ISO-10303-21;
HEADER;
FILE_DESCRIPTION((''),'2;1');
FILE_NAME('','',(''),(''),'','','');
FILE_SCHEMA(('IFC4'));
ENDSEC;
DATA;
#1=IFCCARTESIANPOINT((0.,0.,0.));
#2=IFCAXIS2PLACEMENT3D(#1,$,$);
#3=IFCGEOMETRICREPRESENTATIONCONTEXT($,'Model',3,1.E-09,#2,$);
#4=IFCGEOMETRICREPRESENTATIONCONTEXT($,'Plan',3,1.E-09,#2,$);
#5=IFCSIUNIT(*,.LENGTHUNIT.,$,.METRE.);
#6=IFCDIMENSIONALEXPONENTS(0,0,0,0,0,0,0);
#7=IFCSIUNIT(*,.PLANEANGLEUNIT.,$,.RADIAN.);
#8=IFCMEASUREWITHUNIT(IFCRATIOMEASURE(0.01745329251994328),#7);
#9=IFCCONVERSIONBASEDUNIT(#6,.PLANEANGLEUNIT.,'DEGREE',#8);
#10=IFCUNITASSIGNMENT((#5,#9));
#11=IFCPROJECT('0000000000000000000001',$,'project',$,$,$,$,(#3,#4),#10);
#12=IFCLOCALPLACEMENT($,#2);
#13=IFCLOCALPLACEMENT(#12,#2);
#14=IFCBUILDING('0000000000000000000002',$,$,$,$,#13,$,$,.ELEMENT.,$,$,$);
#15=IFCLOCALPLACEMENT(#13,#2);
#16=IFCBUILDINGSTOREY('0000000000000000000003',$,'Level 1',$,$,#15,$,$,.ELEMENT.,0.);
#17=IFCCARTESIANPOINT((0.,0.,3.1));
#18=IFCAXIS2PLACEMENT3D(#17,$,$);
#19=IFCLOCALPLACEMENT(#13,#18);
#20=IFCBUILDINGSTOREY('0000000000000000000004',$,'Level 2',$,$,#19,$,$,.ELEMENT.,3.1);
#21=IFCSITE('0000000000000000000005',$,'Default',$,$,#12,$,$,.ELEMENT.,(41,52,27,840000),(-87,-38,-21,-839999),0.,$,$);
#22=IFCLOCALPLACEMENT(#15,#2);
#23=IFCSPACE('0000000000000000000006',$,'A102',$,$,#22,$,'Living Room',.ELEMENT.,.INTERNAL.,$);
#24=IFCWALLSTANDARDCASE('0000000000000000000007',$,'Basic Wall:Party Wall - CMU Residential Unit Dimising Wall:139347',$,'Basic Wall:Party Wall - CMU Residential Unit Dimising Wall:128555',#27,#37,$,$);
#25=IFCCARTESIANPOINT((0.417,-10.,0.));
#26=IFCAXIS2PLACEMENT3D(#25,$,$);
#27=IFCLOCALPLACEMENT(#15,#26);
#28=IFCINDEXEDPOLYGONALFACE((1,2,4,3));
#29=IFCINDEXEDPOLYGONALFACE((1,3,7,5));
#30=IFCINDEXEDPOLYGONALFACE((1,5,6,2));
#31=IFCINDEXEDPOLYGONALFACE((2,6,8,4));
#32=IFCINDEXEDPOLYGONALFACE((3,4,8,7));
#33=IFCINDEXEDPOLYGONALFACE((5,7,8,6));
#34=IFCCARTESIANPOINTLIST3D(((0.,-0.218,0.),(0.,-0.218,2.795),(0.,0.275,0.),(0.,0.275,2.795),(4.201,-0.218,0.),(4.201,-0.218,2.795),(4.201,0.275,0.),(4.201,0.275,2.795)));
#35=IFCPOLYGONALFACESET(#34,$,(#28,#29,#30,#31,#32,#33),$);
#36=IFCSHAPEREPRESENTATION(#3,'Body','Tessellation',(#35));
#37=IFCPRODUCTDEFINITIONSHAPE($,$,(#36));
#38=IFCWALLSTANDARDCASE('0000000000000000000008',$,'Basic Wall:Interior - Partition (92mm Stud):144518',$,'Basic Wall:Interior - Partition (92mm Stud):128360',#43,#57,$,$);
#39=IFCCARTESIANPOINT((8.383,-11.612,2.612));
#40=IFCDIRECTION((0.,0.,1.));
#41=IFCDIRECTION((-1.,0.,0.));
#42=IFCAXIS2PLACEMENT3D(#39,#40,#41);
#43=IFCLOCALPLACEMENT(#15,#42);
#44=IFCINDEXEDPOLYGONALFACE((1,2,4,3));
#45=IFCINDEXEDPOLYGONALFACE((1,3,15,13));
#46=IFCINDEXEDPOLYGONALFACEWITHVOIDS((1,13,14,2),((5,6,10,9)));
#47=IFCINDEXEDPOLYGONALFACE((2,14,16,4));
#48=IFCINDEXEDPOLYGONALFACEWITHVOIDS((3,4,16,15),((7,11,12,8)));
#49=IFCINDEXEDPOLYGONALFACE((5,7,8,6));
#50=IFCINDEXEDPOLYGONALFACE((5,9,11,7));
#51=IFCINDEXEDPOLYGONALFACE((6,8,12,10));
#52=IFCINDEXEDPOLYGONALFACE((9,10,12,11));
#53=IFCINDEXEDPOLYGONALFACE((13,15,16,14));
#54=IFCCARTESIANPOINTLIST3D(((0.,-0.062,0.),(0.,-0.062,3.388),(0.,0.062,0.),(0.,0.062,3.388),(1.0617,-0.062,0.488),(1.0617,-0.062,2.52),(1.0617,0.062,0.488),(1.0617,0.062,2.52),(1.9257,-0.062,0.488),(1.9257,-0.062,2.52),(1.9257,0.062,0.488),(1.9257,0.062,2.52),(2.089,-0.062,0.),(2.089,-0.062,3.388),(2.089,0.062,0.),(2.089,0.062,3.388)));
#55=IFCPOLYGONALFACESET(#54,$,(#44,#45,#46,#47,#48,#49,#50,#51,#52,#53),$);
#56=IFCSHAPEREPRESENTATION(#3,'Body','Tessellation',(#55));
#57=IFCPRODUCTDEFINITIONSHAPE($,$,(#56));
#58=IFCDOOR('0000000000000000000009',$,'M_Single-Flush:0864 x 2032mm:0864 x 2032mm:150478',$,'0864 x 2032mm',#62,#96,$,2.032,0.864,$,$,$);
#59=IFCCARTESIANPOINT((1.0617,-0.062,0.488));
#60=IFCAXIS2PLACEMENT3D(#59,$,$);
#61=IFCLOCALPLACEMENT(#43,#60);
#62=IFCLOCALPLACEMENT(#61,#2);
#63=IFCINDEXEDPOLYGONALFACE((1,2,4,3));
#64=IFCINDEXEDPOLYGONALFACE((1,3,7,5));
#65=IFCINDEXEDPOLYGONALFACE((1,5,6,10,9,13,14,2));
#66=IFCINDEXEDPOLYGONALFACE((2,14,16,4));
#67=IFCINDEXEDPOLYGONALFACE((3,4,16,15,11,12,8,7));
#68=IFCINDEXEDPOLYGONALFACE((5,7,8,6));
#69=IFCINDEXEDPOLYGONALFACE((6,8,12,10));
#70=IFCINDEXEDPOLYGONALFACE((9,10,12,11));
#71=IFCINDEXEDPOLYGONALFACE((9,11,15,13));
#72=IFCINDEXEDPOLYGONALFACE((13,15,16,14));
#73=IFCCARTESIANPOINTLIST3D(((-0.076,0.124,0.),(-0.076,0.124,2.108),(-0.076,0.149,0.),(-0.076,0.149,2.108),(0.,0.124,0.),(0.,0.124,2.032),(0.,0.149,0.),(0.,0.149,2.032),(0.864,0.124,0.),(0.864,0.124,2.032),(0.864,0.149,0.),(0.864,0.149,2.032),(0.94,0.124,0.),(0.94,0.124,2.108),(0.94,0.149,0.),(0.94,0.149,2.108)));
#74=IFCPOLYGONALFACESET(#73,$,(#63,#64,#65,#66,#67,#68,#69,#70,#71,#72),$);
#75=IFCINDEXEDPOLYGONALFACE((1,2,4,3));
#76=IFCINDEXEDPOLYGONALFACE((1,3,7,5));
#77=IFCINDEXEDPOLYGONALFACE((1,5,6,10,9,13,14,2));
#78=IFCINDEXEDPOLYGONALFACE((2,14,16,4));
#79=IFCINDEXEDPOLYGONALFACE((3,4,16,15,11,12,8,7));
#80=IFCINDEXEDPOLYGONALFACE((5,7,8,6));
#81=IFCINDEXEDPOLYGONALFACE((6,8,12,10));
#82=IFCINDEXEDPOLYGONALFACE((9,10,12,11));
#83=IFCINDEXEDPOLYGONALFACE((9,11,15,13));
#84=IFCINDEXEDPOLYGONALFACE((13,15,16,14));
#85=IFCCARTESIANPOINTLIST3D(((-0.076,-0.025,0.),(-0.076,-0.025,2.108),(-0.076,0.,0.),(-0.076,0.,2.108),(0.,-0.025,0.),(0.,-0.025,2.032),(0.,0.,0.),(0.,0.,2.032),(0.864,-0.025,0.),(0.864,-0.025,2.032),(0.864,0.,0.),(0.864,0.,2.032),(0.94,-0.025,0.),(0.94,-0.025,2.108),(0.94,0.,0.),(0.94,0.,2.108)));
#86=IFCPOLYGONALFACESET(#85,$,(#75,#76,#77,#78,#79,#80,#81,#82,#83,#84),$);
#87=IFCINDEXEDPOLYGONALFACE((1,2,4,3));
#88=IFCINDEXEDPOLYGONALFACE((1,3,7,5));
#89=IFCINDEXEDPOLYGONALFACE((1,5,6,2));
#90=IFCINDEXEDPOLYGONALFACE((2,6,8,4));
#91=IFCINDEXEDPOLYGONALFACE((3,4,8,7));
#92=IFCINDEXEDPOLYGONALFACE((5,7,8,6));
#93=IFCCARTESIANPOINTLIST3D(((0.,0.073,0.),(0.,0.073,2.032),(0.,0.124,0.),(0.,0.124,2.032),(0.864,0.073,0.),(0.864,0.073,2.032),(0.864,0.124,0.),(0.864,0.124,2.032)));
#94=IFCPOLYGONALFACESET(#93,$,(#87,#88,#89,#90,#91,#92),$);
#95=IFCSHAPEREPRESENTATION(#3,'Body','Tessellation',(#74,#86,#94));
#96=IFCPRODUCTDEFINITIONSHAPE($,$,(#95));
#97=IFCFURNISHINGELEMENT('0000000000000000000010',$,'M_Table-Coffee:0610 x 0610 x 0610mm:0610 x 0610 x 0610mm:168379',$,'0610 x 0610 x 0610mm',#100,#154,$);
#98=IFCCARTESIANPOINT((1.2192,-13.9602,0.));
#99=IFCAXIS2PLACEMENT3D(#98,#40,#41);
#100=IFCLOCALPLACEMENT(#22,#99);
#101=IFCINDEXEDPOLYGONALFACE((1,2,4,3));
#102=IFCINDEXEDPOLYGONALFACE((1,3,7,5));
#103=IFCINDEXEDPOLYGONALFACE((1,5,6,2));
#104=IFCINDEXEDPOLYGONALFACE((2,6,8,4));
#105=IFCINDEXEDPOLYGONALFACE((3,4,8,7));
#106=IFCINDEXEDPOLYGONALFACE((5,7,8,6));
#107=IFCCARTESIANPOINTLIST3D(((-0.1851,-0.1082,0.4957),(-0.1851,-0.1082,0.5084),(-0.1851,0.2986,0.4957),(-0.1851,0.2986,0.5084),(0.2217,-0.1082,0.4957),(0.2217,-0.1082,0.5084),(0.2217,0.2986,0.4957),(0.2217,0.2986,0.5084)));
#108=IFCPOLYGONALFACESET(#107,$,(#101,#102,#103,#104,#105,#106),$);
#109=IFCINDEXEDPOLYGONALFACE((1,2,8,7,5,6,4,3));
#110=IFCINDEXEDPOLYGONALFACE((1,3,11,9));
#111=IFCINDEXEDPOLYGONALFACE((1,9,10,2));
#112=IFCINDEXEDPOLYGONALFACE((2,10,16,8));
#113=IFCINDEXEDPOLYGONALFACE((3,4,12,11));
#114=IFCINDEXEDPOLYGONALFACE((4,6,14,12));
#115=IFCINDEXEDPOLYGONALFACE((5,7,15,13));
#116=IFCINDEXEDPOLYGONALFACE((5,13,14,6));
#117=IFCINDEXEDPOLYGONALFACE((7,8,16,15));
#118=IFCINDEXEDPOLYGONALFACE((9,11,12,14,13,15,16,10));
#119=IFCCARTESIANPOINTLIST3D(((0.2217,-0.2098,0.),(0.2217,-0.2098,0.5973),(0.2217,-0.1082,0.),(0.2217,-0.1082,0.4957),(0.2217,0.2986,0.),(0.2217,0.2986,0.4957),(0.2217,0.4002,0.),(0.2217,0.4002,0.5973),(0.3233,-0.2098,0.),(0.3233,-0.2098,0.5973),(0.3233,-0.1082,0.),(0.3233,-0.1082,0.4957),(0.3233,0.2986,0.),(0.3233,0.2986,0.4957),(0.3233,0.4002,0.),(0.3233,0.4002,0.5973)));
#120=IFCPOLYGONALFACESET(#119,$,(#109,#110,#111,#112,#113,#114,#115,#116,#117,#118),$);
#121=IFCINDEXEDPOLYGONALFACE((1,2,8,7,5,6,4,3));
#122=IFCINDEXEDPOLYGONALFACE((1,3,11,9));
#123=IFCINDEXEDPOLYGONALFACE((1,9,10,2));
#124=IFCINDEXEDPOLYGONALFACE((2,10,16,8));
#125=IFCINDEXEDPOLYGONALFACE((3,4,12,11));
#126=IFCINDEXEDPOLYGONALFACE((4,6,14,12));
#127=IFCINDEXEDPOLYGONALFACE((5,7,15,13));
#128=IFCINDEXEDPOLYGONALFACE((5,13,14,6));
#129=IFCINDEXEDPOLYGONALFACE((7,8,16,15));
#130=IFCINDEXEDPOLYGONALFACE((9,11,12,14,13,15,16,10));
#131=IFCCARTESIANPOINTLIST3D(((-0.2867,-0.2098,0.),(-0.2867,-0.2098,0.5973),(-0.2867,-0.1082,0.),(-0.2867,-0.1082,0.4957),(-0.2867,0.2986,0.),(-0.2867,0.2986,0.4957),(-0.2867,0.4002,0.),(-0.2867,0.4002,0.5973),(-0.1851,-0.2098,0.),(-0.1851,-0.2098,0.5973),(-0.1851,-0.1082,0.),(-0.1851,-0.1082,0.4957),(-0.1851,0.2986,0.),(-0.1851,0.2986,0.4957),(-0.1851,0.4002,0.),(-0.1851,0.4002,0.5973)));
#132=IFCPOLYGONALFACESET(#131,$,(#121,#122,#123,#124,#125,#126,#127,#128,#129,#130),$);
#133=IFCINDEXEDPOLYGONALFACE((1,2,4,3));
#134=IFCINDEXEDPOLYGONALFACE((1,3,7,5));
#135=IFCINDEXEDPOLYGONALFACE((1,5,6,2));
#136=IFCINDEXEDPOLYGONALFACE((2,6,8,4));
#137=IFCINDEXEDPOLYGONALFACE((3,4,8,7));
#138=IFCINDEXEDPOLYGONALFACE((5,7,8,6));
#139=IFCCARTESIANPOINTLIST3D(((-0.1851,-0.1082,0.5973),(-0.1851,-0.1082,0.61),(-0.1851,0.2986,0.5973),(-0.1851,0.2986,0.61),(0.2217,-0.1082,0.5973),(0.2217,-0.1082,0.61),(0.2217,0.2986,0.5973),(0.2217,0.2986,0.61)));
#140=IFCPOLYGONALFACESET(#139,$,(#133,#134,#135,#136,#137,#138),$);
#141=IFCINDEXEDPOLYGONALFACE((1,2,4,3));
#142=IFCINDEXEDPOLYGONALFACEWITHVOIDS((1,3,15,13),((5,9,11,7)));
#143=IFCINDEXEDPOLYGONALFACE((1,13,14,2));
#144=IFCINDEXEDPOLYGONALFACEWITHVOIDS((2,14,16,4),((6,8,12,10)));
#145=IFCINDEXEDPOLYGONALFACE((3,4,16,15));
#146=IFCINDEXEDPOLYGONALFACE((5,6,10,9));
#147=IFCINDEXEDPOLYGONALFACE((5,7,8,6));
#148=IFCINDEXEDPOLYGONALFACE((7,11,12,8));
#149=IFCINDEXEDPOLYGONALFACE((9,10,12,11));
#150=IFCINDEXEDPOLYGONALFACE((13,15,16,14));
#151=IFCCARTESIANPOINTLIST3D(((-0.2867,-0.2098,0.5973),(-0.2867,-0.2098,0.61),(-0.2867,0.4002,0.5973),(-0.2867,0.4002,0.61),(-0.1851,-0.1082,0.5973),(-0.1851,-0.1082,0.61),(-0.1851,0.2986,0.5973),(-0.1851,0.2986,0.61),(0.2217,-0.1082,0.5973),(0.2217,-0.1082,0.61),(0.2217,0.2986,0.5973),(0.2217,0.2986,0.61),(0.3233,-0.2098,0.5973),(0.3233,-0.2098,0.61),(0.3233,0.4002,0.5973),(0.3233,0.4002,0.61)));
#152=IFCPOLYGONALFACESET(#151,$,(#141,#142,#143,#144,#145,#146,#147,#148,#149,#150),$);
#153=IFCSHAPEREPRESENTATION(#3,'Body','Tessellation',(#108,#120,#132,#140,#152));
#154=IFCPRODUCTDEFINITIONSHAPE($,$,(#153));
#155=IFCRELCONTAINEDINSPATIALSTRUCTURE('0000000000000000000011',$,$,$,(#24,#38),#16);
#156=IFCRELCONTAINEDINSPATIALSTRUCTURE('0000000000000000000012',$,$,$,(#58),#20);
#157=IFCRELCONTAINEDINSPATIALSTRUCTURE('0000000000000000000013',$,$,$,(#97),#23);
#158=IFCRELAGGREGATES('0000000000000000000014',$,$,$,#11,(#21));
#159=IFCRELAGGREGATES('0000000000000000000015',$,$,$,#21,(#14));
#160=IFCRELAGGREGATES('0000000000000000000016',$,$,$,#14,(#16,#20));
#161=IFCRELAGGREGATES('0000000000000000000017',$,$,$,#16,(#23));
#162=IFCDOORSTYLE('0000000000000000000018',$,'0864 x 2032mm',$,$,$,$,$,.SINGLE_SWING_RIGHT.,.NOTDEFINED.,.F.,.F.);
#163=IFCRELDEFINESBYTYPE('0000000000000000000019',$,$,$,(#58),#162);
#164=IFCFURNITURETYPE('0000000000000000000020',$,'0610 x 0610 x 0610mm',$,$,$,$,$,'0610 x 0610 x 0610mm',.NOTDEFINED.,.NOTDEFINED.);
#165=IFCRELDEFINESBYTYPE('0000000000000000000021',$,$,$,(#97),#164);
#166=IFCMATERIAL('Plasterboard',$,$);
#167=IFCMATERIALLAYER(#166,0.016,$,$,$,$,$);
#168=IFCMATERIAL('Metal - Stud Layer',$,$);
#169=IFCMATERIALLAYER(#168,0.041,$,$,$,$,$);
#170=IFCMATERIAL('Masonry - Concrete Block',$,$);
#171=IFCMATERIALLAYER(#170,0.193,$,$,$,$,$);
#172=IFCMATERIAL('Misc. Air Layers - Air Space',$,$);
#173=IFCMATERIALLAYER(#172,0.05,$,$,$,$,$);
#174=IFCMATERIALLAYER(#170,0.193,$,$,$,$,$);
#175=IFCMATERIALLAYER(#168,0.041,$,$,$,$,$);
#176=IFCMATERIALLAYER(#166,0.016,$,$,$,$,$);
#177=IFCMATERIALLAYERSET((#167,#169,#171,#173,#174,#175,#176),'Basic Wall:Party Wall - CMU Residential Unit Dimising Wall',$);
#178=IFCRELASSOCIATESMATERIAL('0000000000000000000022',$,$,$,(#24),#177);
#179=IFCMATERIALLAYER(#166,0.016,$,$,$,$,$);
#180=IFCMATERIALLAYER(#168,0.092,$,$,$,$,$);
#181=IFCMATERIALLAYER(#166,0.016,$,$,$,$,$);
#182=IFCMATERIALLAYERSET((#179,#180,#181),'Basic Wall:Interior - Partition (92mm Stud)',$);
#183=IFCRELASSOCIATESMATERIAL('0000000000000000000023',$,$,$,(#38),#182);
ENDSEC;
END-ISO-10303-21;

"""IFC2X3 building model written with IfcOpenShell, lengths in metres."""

from ifc_helpers import new_model, entity, si_unit, converted_unit, frame, frame_2d, origin, origin_2d_with_axis, place, context, project, spatial, polyline, rectangle, outline, extrude, clip, bounded_halfspace, source, transform, mapped, material, layer, layer_set, layer_usage, type_object, type_shapes, element, fill, save


model = new_model("IFC2X3")

# Units and contexts
model_context = context("Model", 3, precision=1e-09, world=origin())
plan_context = context("Plan", 3, precision=1e-09, world=origin())
ifc_project = project(units=[si_unit("LENGTHUNIT", "METRE"), converted_unit("PLANEANGLEUNIT", "DEGREE", entity("IfcRatioMeasure", 0.01745329251994328), si_unit("PLANEANGLEUNIT", "RADIAN"), dimensions=[0, 0, 0, 0, 0, 0, 0])], contexts=[model_context, plan_context])

# Site, building, storey
site_placement = place(None, origin())
site = spatial("IfcSite", under=ifc_project, at=site_placement, Name="Default", CompositionType="ELEMENT", RefLatitude=(41, 52, 27, 840000), RefLongitude=(-87, -38, -21, -839999), RefElevation=0.0)
building_placement = place(site_placement, origin())
building = spatial("IfcBuilding", under=site, at=building_placement, CompositionType="ELEMENT")
storey_1_placement = place(building_placement, origin())
storey_1 = spatial("IfcBuildingStorey", under=building, at=storey_1_placement, Name="Level 1", CompositionType="ELEMENT", Elevation=0.0)

# Shared definitions
ifc_material_1 = material(Name="Misc. Air Layers - Air Space")
ifc_material_2 = material(Name="Masonry - Concrete Block")
ifc_material_3 = material(Name="Metal - Stud Layer")
ifc_material_4 = material(Name="Plasterboard")

# Wall
ifc_layer_1 = layer(ifc_material_4, 0.016)
ifc_layer_2 = layer(ifc_material_3, 0.041)
ifc_layer_3 = layer(ifc_material_2, 0.193)
ifc_layer_4 = layer(ifc_material_1, 0.05)
ifc_layer_5 = layer(ifc_material_2, 0.193)
ifc_layer_6 = layer(ifc_material_3, 0.041)
ifc_layer_7 = layer(ifc_material_4, 0.016)
ifc_layer_set_1 = layer_set([ifc_layer_1, ifc_layer_2, ifc_layer_3, ifc_layer_4, ifc_layer_5, ifc_layer_6, ifc_layer_7], Name="Basic Wall:Party Wall - CMU Residential Unit Dimising Wall")
ifc_layer_usage_1 = layer_usage(ifc_layer_set_1, "AXIS2", "NEGATIVE", 0.275)
wall_1_placement = place(storey_1_placement, frame((0.417, -10.0, 0.0)))
element("IfcWallStandardCase", 1, at=wall_1_placement, inside=storey_1, material=ifc_layer_usage_1, Name="Basic Wall:Party Wall - CMU Residential Unit Dimising Wall:139347", ObjectType="Basic Wall:Party Wall - CMU Residential Unit Dimising Wall:128555", context=model_context, shape_type="Clipping", body=[
    clip(clip(extrude(rectangle(XDim=4.201, YDim=0.55, at=frame_2d((2.1005, 0.0), x_axis=(-1.0, 0.0))), origin(), (0.0, 0.0, 1.0), 2.795), bounded_halfspace(frame((0.0, -0.218, 0.0), z_axis=(0.0, 1.0, 0.0), x_axis=(-1.0, 0.0, 0.0)), True, frame((0.0, -0.218, 0.0), z_axis=(0.0, 1.0, 0.0), x_axis=(-1.0, 0.0, 0.0)), polyline([(0.0, 0.0), (0.0, 2.795), (-4.201, 2.795), (-4.201, 0.0), (0.0, 0.0)]))), bounded_halfspace(frame((4.201, 0.275, 0.0), z_axis=(-1.0, 0.0, 0.0), x_axis=(0.0, -1.0, 0.0)), True, frame((4.201, 0.275, 0.0), z_axis=(-1.0, 0.0, 0.0), x_axis=(0.0, -1.0, 0.0)), polyline([(0.0, 0.0), (0.493, 0.0), (0.493, 2.795), (0.0, 2.795), (0.0, 0.0)]))),
])
ifc_layer_8 = layer(ifc_material_4, 0.016)
ifc_layer_9 = layer(ifc_material_3, 0.092)
ifc_layer_10 = layer(ifc_material_4, 0.016)
ifc_layer_set_2 = layer_set([ifc_layer_8, ifc_layer_9, ifc_layer_10], Name="Basic Wall:Interior - Partition (92mm Stud)")
ifc_layer_usage_2 = layer_usage(ifc_layer_set_2, "AXIS2", "NEGATIVE", 0.062)

# Wall, opening
wall_2_placement = place(storey_1_placement, frame((8.383, -11.612, 2.612), z_axis=(0.0, 0.0, 1.0), x_axis=(-1.0, 0.0, 0.0)))
wall_2 = element("IfcWallStandardCase", 2, at=wall_2_placement, inside=storey_1, material=ifc_layer_usage_2, Name="Basic Wall:Interior - Partition (92mm Stud):144518", ObjectType="Basic Wall:Interior - Partition (92mm Stud):128360", context=model_context, shape_type="SweptSolid", body=[
    extrude(rectangle(XDim=2.089, YDim=0.124, at=frame_2d((1.0445, 0.0), x_axis=(-1.0, 0.0))), origin(), (0.0, 0.0, 1.0), 3.388),
])
opening_1_placement = place(wall_2_placement, frame((1.0617, -0.062, 0.488)))
opening_1 = element("IfcOpeningElement", 3, at=opening_1_placement, cuts=wall_2, ObjectType="Opening", context=model_context, shape_type="SweptSolid", body=[
    extrude(rectangle(XDim=0.864, YDim=2.032, at=frame_2d((1.016, 0.432), x_axis=(0.0, 1.0))), frame((0.0, 0.0, 0.0), z_axis=(0.0, 1.0, 0.0), x_axis=(0.0, 0.0, 1.0)), (0.0, 0.0, 1.0), 0.124),
])

# Shared definitions
storey_2_placement = place(building_placement, frame((0.0, 0.0, 3.1)))
storey_2 = spatial("IfcBuildingStorey", under=building, at=storey_2_placement, Name="Level 2", CompositionType="ELEMENT", Elevation=3.1)

# Door
door_style_1 = type_object("IfcDoorStyle", Name="0864 x 2032mm", ConstructionType="NOTDEFINED", OperationType="SINGLE_SWING_RIGHT", ParameterTakesPrecedence=False, Sizeable=False)
shared_shape_1 = source(origin(), model_context, "Body", "SweptSolid", [
    extrude(outline(polyline([(-0.508, -1.073), (0.508, -1.073), (0.508, 1.035), (0.432, 1.035), (0.432, -0.997), (-0.432, -0.997), (-0.432, 1.035), (-0.508, 1.035), (-0.508, -1.073)])), frame((0.432, 0.124, 1.035), z_axis=(0.0, 1.0, 0.0), x_axis=(1.0, 0.0, 0.0)), (0.0, 0.0, 1.0), 0.025),
    extrude(outline(polyline([(-1.073, -0.508), (1.035, -0.508), (1.035, -0.432), (-0.997, -0.432), (-0.997, 0.432), (1.035, 0.432), (1.035, 0.508), (-1.073, 0.508), (-1.073, -0.508)])), frame((0.432, -0.025, 1.035), z_axis=(0.0, 1.0, 0.0), x_axis=(0.0, 0.0, -1.0)), (0.0, 0.0, 1.0), 0.025),
    extrude(rectangle(XDim=0.051, YDim=0.864, at=origin_2d_with_axis()), frame((0.432, 0.0985, 0.0), z_axis=(0.0, 0.0, 1.0), x_axis=(0.0, 1.0, 0.0)), (0.0, 0.0, 1.0), 2.032),
])
type_shapes(door_style_1, [shared_shape_1])
door_1_placement = place(opening_1_placement, origin())
door_1 = element("IfcDoor", 4, at=door_1_placement, inside=storey_2, type_object=door_style_1, Name="M_Single-Flush:0864 x 2032mm:0864 x 2032mm:150478", ObjectType="0864 x 2032mm", OverallHeight=2.032, OverallWidth=0.864, context=model_context, shape_type="MappedRepresentation", body=[
    mapped(shared_shape_1, transform((0.0, 0.0, 0.0), scale=1.0)),
])
fill(opening_1, door_1)

# Shared definitions
space_1_placement = place(storey_1_placement, origin())
space_1 = spatial("IfcSpace", under=storey_1, at=space_1_placement, Name="A102", LongName="Living Room", CompositionType="ELEMENT", InteriorOrExteriorSpace="INTERNAL")

# Furnishing element
furniture_type_1 = type_object("IfcFurnitureType", Name="0610 x 0610 x 0610mm", ElementType="0610 x 0610 x 0610mm", AssemblyPlace="NOTDEFINED")
shared_shape_2 = source(origin(), model_context, "Body", "SweptSolid", [
    extrude(rectangle(XDim=0.4068, YDim=0.4068, at=origin_2d_with_axis()), frame((0.0183, 0.0952, 0.4957), z_axis=(0.0, 0.0, 1.0), x_axis=(-1.0, 0.0, 0.0)), (0.0, 0.0, 1.0), 0.0127),
    extrude(outline(polyline([(-0.2732, -0.305), (0.324, -0.305), (0.324, 0.305), (-0.2732, 0.305), (-0.2732, 0.2034), (0.2225, 0.2034), (0.2225, -0.2034), (-0.2732, -0.2034), (-0.2732, -0.305)])), frame((0.2217, 0.0952, 0.2732), z_axis=(1.0, 0.0, 0.0), x_axis=(0.0, 0.0, 1.0)), (0.0, 0.0, 1.0), 0.1016),
    extrude(outline(polyline([(-0.305, -0.3241), (0.305, -0.3241), (0.305, 0.2733), (0.2034, 0.2733), (0.2034, -0.2224), (-0.2034, -0.2224), (-0.2034, 0.2733), (-0.305, 0.2733), (-0.305, -0.3241)])), frame((-0.2867, 0.0952, 0.2733), z_axis=(1.0, 0.0, 0.0), x_axis=(0.0, -1.0, 0.0)), (0.0, 0.0, 1.0), 0.1016),
    extrude(rectangle(XDim=0.4068, YDim=0.4068, at=origin_2d_with_axis()), frame((0.0183, 0.0952, 0.5973), z_axis=(0.0, 0.0, 1.0), x_axis=(-1.0, 0.0, 0.0)), (0.0, 0.0, 1.0), 0.0127),
    extrude(outline(polyline([(-0.305, -0.305), (0.305, -0.305), (0.305, 0.305), (-0.305, 0.305), (-0.305, -0.305)]), holes=[polyline([(-0.2034, -0.2034), (-0.2034, 0.2034), (0.2034, 0.2034), (0.2034, -0.2034), (-0.2034, -0.2034)])]), frame((0.0183, 0.0952, 0.5973), z_axis=(0.0, 0.0, 1.0), x_axis=(-1.0, 0.0, 0.0)), (0.0, 0.0, 1.0), 0.0127),
])
type_shapes(furniture_type_1, [shared_shape_2])
for number, where, z_axis, x_axis, name in (
    (5, (1.2192, -13.9602, 0.0), (0.0, 0.0, 1.0), (-1.0, 0.0, 0.0), "M_Table-Coffee:0610 x 0610 x 0610mm:0610 x 0610 x 0610mm:168379"),
):
    element("IfcFurnishingElement", number, at=place(space_1_placement, frame(where, z_axis=z_axis, x_axis=x_axis)), inside=space_1, type_object=furniture_type_1, Name=name, ObjectType="0610 x 0610 x 0610mm", context=model_context, shape_type="MappedRepresentation", body=[
        mapped(shared_shape_2, transform((0.0, 0.0, 0.0), scale=1.0)),
    ])

save(model, "model.ifc")
